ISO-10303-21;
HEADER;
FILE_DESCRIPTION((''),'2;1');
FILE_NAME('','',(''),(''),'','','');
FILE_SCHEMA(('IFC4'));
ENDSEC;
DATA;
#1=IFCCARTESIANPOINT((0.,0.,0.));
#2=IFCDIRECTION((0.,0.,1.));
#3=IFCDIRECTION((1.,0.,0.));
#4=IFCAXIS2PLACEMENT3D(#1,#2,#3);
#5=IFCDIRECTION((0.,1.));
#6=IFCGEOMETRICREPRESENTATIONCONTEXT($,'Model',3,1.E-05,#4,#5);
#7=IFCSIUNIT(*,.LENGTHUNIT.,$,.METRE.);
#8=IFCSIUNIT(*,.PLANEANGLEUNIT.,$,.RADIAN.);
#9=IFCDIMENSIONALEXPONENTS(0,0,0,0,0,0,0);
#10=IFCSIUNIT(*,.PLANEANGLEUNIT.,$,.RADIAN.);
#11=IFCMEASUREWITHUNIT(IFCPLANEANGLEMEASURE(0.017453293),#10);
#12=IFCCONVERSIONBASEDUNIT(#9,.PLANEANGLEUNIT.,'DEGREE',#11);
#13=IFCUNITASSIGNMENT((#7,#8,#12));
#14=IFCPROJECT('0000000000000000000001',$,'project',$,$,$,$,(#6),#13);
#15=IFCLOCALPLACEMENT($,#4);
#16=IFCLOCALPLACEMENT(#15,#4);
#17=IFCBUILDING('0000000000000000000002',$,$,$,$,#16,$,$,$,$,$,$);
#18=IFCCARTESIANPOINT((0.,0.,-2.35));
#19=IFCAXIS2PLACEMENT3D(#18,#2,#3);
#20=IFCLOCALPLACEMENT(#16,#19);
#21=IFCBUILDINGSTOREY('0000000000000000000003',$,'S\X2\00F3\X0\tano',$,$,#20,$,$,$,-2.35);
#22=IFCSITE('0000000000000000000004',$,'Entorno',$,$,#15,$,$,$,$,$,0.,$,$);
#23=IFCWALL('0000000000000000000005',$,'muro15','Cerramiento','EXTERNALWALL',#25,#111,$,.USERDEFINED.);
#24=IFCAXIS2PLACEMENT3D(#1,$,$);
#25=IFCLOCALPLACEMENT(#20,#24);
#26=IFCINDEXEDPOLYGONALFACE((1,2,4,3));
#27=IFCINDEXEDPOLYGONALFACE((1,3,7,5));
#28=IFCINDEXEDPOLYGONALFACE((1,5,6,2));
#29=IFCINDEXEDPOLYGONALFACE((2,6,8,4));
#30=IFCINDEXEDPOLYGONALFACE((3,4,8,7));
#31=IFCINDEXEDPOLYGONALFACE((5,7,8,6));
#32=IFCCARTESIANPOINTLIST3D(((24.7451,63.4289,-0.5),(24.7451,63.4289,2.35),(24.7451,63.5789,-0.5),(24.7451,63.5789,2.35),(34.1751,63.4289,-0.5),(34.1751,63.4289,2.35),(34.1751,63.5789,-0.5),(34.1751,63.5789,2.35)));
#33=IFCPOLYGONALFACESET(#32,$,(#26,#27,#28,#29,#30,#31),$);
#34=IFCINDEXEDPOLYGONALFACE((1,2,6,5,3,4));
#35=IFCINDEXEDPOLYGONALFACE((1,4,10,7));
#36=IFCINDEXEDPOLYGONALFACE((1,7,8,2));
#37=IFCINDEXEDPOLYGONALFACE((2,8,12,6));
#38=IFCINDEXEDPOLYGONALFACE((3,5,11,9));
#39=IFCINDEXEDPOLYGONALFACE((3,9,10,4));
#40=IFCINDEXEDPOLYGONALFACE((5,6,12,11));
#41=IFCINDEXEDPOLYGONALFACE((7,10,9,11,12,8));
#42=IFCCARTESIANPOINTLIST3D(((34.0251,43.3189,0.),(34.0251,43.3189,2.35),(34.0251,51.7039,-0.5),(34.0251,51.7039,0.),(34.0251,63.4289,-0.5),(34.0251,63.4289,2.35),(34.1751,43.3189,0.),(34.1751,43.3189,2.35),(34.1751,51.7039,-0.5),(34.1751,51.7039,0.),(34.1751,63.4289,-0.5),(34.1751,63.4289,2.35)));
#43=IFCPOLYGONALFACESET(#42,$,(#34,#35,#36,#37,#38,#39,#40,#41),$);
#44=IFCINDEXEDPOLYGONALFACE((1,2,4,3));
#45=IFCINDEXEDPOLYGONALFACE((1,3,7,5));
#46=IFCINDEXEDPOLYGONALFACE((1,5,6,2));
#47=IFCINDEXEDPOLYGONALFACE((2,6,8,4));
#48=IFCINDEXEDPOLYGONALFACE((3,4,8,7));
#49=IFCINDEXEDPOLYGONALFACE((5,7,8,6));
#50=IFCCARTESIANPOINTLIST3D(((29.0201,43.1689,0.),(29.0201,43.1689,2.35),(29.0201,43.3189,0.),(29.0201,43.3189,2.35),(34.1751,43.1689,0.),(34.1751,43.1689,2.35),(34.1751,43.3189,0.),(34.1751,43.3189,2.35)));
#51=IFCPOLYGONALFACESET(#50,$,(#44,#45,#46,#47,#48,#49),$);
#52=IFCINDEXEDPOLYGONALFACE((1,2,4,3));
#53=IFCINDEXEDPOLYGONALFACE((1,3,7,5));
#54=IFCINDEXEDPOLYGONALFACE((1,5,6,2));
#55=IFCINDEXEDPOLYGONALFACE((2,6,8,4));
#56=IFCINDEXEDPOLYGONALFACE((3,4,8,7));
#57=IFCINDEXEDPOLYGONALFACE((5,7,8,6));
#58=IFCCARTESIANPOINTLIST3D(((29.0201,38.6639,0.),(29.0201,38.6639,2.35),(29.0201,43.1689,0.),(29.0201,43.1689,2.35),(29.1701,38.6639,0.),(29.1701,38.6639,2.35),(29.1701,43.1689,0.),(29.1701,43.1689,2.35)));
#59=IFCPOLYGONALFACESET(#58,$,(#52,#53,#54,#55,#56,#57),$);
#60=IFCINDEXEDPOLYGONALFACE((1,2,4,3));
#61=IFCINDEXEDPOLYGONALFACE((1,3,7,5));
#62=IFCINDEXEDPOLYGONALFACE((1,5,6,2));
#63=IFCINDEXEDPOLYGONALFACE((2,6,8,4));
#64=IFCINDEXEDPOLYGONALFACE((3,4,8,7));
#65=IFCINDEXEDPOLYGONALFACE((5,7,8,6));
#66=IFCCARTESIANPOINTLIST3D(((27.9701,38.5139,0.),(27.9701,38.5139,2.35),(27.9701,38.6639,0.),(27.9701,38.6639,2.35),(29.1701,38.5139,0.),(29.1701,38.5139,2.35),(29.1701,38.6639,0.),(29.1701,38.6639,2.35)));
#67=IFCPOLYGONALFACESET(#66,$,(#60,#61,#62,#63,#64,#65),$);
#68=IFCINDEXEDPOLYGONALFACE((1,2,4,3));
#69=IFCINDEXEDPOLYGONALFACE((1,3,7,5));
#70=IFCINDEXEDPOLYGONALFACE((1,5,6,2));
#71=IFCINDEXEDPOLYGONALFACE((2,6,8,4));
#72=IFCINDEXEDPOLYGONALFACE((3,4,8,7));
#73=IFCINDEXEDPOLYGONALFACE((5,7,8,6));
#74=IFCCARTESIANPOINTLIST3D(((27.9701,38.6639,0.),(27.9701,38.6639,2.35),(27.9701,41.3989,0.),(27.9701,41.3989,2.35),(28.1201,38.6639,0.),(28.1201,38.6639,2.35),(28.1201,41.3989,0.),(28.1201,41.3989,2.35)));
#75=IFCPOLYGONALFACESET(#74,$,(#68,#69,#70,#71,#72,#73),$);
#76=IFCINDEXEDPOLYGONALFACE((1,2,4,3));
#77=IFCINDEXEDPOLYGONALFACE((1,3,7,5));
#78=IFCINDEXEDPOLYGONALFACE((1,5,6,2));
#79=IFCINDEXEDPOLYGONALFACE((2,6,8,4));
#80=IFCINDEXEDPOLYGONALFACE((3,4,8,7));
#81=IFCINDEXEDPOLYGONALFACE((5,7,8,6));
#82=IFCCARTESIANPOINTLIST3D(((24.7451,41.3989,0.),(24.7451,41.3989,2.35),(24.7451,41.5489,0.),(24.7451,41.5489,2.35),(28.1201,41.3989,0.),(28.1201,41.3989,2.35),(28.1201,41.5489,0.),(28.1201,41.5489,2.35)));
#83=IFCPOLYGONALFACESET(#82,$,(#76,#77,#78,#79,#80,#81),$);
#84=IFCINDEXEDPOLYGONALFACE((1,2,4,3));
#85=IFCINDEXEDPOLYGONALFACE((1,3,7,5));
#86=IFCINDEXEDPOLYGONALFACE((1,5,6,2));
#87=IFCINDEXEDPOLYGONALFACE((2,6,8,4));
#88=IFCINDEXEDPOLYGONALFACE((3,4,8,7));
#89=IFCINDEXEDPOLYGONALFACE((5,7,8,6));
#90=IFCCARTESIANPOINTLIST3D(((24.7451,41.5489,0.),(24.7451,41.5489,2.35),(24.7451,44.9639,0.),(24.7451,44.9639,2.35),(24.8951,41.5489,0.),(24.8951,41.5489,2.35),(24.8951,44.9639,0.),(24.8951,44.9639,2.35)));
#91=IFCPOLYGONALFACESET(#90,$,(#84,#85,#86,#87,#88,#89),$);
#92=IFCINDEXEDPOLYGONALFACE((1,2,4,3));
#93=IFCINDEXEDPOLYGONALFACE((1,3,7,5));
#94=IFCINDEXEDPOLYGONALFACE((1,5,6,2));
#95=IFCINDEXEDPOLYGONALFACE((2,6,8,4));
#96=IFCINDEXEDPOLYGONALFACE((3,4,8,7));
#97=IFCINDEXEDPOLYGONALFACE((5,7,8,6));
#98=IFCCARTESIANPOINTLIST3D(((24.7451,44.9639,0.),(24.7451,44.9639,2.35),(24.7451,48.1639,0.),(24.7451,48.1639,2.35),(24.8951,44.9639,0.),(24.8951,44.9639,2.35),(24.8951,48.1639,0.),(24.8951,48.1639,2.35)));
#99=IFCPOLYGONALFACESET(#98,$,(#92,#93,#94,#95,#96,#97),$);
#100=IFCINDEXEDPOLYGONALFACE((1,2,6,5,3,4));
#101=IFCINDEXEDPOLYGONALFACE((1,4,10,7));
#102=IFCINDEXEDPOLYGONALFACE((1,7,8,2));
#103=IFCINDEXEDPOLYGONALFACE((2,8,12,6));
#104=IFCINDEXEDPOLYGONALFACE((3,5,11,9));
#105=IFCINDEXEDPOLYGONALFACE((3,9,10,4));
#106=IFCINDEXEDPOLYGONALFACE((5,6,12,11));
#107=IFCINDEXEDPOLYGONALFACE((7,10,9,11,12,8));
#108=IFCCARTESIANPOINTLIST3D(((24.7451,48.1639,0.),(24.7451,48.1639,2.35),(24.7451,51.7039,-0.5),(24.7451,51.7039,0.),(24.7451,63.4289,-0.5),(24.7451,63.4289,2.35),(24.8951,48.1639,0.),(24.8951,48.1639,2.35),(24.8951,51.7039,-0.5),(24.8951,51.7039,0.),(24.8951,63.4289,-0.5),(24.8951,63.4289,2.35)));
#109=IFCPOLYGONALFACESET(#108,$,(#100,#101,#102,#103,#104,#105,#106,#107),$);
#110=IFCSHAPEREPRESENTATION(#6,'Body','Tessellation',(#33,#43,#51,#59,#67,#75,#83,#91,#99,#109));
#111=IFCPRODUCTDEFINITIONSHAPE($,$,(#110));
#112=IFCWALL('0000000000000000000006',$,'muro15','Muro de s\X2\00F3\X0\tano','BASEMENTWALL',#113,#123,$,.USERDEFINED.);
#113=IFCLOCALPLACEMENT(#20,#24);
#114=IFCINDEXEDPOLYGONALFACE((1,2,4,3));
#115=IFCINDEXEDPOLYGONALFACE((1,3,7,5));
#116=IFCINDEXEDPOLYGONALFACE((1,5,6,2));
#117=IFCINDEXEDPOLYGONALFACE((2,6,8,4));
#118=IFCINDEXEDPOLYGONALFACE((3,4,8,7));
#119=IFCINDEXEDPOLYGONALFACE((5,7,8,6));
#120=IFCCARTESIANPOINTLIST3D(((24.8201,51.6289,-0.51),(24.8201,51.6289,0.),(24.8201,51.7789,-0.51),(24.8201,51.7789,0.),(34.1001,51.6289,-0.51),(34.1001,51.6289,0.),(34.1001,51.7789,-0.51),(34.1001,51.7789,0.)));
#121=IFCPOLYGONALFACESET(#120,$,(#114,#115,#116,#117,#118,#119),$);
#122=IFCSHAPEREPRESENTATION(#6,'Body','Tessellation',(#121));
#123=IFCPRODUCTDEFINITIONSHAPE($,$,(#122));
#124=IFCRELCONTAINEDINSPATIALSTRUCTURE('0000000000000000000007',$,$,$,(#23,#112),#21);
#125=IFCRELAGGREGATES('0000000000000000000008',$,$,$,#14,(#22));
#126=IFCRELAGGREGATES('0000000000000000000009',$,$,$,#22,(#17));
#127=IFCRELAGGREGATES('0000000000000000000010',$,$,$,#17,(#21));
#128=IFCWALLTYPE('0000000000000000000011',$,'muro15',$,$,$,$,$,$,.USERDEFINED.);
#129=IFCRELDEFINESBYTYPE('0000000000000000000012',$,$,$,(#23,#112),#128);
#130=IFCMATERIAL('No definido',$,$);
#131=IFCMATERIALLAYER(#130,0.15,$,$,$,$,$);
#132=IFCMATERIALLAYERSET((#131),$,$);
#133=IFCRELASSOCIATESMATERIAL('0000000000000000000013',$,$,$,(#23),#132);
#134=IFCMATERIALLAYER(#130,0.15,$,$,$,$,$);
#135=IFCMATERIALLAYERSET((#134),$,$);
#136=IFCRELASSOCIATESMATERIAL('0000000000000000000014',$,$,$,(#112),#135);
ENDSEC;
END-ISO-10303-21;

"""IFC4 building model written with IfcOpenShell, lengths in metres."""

from ifc_helpers import new_model, entity, si_unit, converted_unit, direction, frame, origin_with_axes, place, context, project, spatial, material, layer, layer_set, layer_usage, type_object, element, save


model = new_model("IFC4")

# Units and contexts
model_context = context("Model", 3, precision=1e-05, world=origin_with_axes(), true_north=direction((0.0, 1.0)))
ifc_project = project(units=[si_unit("LENGTHUNIT", "METRE"), si_unit("PLANEANGLEUNIT", "RADIAN"), converted_unit("PLANEANGLEUNIT", "DEGREE", entity("IfcPlaneAngleMeasure", 0.017453293), si_unit("PLANEANGLEUNIT", "RADIAN"), dimensions=[0, 0, 0, 0, 0, 0, 0])], contexts=[model_context])

# Site, building, storey
site_placement = place(None, origin_with_axes())
site = spatial("IfcSite", under=ifc_project, at=site_placement, Name="Entorno", RefElevation=0.0)
building_placement = place(site_placement, origin_with_axes())
building = spatial("IfcBuilding", under=site, at=building_placement)
storey_placement = place(building_placement, frame((0.0, 0.0, -2.35), z_axis=(0.0, 0.0, 1.0), x_axis=(1.0, 0.0, 0.0)))
storey = spatial("IfcBuildingStorey", under=building, at=storey_placement, Name="Sótano", Elevation=-2.35)

# Shared definitions
ifc_material = material(Name="No definido")

# Walls
ifc_layer_1 = layer(ifc_material, 0.15)
ifc_layer_set_1 = layer_set([ifc_layer_1])
ifc_layer_usage_1 = layer_usage(ifc_layer_set_1, "AXIS2", "POSITIVE", -0.075)
wall_type_1 = type_object("IfcWallType", Name="muro15", PredefinedType="USERDEFINED")
wall_1_placement = place(storey_placement, frame((24.8201, 63.5039, 0.0), z_axis=(0.0, 0.0, 1.0), x_axis=(1.0, 0.0, 0.0)))
cartesian_point_1 = entity("IfcCartesianPoint", [-4.715, -1.425])
cartesian_point_2 = entity("IfcCartesianPoint", [-4.715, -1.425])
cartesian_point_3 = entity("IfcCartesianPoint", [-10.055, -1.425])
cartesian_point_4 = entity("IfcCartesianPoint", [-10.055, -1.425])
cartesian_point_5 = entity("IfcCartesianPoint", [-2.5775, -1.175])
cartesian_point_6 = entity("IfcCartesianPoint", [-2.5775, -1.175])
cartesian_point_7 = entity("IfcCartesianPoint", [-2.2525, -1.175])
cartesian_point_8 = entity("IfcCartesianPoint", [-2.2525, -1.175])
cartesian_point_9 = entity("IfcCartesianPoint", [-0.6, -1.175])
cartesian_point_10 = entity("IfcCartesianPoint", [-0.6, -1.175])
cartesian_point_11 = entity("IfcCartesianPoint", [-1.3675, -1.175])
cartesian_point_12 = entity("IfcCartesianPoint", [-1.3675, -1.175])
cartesian_point_13 = entity("IfcCartesianPoint", [-1.6875, -1.175])
cartesian_point_14 = entity("IfcCartesianPoint", [-1.6875, -1.175])
cartesian_point_15 = entity("IfcCartesianPoint", [-1.7075, -1.175])
cartesian_point_16 = entity("IfcCartesianPoint", [-1.7075, -1.175])
cartesian_point_17 = entity("IfcCartesianPoint", [-1.6, -1.175])
cartesian_point_18 = entity("IfcCartesianPoint", [-1.6, -1.175])
cartesian_point_19 = entity("IfcCartesianPoint", [-7.6325, -0.925])
cartesian_point_20 = entity("IfcCartesianPoint", [-7.6325, -0.925])
element("IfcWall", 1, at=wall_1_placement, inside=storey, type_object=wall_type_1, material=ifc_layer_usage_1, Name="muro15", Description="Cerramiento", ObjectType="EXTERNALWALL", PredefinedType="USERDEFINED", context=model_context, shape_type="SolidModel", body=[
    entity("IfcExtrudedAreaSolidTapered", entity("IfcArbitraryClosedProfileDef", "AREA", None, entity("IfcPolyline", [cartesian_point_1, entity("IfcCartesianPoint", [4.715, -1.425]), entity("IfcCartesianPoint", [4.715, 1.425]), entity("IfcCartesianPoint", [-4.715, 1.425]), cartesian_point_1])), entity("IfcAxis2Placement3D", entity("IfcCartesianPoint", [4.64, 0.075, 0.925]), entity("IfcDirection", [0.0, -1.0, 0.0]), entity("IfcDirection", [1.0, 0.0, 0.0])), entity("IfcDirection", [0.0, 0.0, 1.0]), 0.15, entity("IfcArbitraryClosedProfileDef", "AREA", None, entity("IfcPolyline", [cartesian_point_2, entity("IfcCartesianPoint", [4.715, -1.425]), entity("IfcCartesianPoint", [4.715, 1.425]), entity("IfcCartesianPoint", [-4.715, 1.425]), cartesian_point_2]))),
    entity("IfcExtrudedAreaSolidTapered", entity("IfcArbitraryClosedProfileDef", "AREA", None, entity("IfcPolyline", [cartesian_point_3, entity("IfcCartesianPoint", [1.67, -1.425]), entity("IfcCartesianPoint", [1.67, -0.925]), entity("IfcCartesianPoint", [10.055, -0.925]), entity("IfcCartesianPoint", [10.055, 1.425]), entity("IfcCartesianPoint", [-10.055, 1.425]), cartesian_point_3])), entity("IfcAxis2Placement3D", entity("IfcCartesianPoint", [9.355, -10.13, 0.925]), entity("IfcDirection", [-1.0, 0.0, 0.0]), entity("IfcDirection", [0.0, -1.0, 0.0])), entity("IfcDirection", [0.0, 0.0, 1.0]), 0.15, entity("IfcArbitraryClosedProfileDef", "AREA", None, entity("IfcPolyline", [cartesian_point_4, entity("IfcCartesianPoint", [1.67, -1.425]), entity("IfcCartesianPoint", [1.67, -0.925]), entity("IfcCartesianPoint", [10.055, -0.925]), entity("IfcCartesianPoint", [10.055, 1.425]), entity("IfcCartesianPoint", [-10.055, 1.425]), cartesian_point_4]))),
    entity("IfcExtrudedAreaSolidTapered", entity("IfcArbitraryClosedProfileDef", "AREA", None, entity("IfcPolyline", [cartesian_point_5, entity("IfcCartesianPoint", [2.5775, -1.175]), entity("IfcCartesianPoint", [2.5775, 1.175]), entity("IfcCartesianPoint", [-2.5775, 1.175]), cartesian_point_5])), entity("IfcAxis2Placement3D", entity("IfcCartesianPoint", [6.7775, -20.335, 1.175]), entity("IfcDirection", [0.0, 1.0, 0.0]), entity("IfcDirection", [-1.0, 0.0, 0.0])), entity("IfcDirection", [0.0, 0.0, 1.0]), 0.15, entity("IfcArbitraryClosedProfileDef", "AREA", None, entity("IfcPolyline", [cartesian_point_6, entity("IfcCartesianPoint", [2.5775, -1.175]), entity("IfcCartesianPoint", [2.5775, 1.175]), entity("IfcCartesianPoint", [-2.5775, 1.175]), cartesian_point_6]))),
    entity("IfcExtrudedAreaSolidTapered", entity("IfcArbitraryClosedProfileDef", "AREA", None, entity("IfcPolyline", [cartesian_point_7, entity("IfcCartesianPoint", [2.2525, -1.175]), entity("IfcCartesianPoint", [2.2525, 1.175]), entity("IfcCartesianPoint", [-2.2525, 1.175]), cartesian_point_7])), entity("IfcAxis2Placement3D", entity("IfcCartesianPoint", [4.35, -22.5875, 1.175]), entity("IfcDirection", [-1.0, 0.0, 0.0]), entity("IfcDirection", [0.0, -1.0, 0.0])), entity("IfcDirection", [0.0, 0.0, 1.0]), 0.15, entity("IfcArbitraryClosedProfileDef", "AREA", None, entity("IfcPolyline", [cartesian_point_8, entity("IfcCartesianPoint", [2.2525, -1.175]), entity("IfcCartesianPoint", [2.2525, 1.175]), entity("IfcCartesianPoint", [-2.2525, 1.175]), cartesian_point_8]))),
    entity("IfcExtrudedAreaSolidTapered", entity("IfcArbitraryClosedProfileDef", "AREA", None, entity("IfcPolyline", [cartesian_point_9, entity("IfcCartesianPoint", [0.6, -1.175]), entity("IfcCartesianPoint", [0.6, 1.175]), entity("IfcCartesianPoint", [-0.6, 1.175]), cartesian_point_9])), entity("IfcAxis2Placement3D", entity("IfcCartesianPoint", [3.75, -24.99, 1.175]), entity("IfcDirection", [0.0, 1.0, 0.0]), entity("IfcDirection", [-1.0, 0.0, 0.0])), entity("IfcDirection", [0.0, 0.0, 1.0]), 0.15, entity("IfcArbitraryClosedProfileDef", "AREA", None, entity("IfcPolyline", [cartesian_point_10, entity("IfcCartesianPoint", [0.6, -1.175]), entity("IfcCartesianPoint", [0.6, 1.175]), entity("IfcCartesianPoint", [-0.6, 1.175]), cartesian_point_10]))),
    entity("IfcExtrudedAreaSolidTapered", entity("IfcArbitraryClosedProfileDef", "AREA", None, entity("IfcPolyline", [cartesian_point_11, entity("IfcCartesianPoint", [1.3675, -1.175]), entity("IfcCartesianPoint", [1.3675, 1.175]), entity("IfcCartesianPoint", [-1.3675, 1.175]), cartesian_point_11])), entity("IfcAxis2Placement3D", entity("IfcCartesianPoint", [3.15, -23.4725, 1.175]), entity("IfcDirection", [1.0, 0.0, 0.0]), entity("IfcDirection", [0.0, 1.0, 0.0])), entity("IfcDirection", [0.0, 0.0, 1.0]), 0.15, entity("IfcArbitraryClosedProfileDef", "AREA", None, entity("IfcPolyline", [cartesian_point_12, entity("IfcCartesianPoint", [1.3675, -1.175]), entity("IfcCartesianPoint", [1.3675, 1.175]), entity("IfcCartesianPoint", [-1.3675, 1.175]), cartesian_point_12]))),
    entity("IfcExtrudedAreaSolidTapered", entity("IfcArbitraryClosedProfileDef", "AREA", None, entity("IfcPolyline", [cartesian_point_13, entity("IfcCartesianPoint", [1.6875, -1.175]), entity("IfcCartesianPoint", [1.6875, 1.175]), entity("IfcCartesianPoint", [-1.6875, 1.175]), cartesian_point_13])), entity("IfcAxis2Placement3D", entity("IfcCartesianPoint", [1.6125, -22.105, 1.175]), entity("IfcDirection", [0.0, 1.0, 0.0]), entity("IfcDirection", [-1.0, 0.0, 0.0])), entity("IfcDirection", [0.0, 0.0, 1.0]), 0.15, entity("IfcArbitraryClosedProfileDef", "AREA", None, entity("IfcPolyline", [cartesian_point_14, entity("IfcCartesianPoint", [1.6875, -1.175]), entity("IfcCartesianPoint", [1.6875, 1.175]), entity("IfcCartesianPoint", [-1.6875, 1.175]), cartesian_point_14]))),
    entity("IfcExtrudedAreaSolidTapered", entity("IfcArbitraryClosedProfileDef", "AREA", None, entity("IfcPolyline", [cartesian_point_15, entity("IfcCartesianPoint", [1.7075, -1.175]), entity("IfcCartesianPoint", [1.7075, 1.175]), entity("IfcCartesianPoint", [-1.7075, 1.175]), cartesian_point_15])), entity("IfcAxis2Placement3D", entity("IfcCartesianPoint", [-0.075, -20.2475, 1.175]), entity("IfcDirection", [1.0, 0.0, 0.0]), entity("IfcDirection", [0.0, 1.0, 0.0])), entity("IfcDirection", [0.0, 0.0, 1.0]), 0.15, entity("IfcArbitraryClosedProfileDef", "AREA", None, entity("IfcPolyline", [cartesian_point_16, entity("IfcCartesianPoint", [1.7075, -1.175]), entity("IfcCartesianPoint", [1.7075, 1.175]), entity("IfcCartesianPoint", [-1.7075, 1.175]), cartesian_point_16]))),
    entity("IfcExtrudedAreaSolidTapered", entity("IfcArbitraryClosedProfileDef", "AREA", None, entity("IfcPolyline", [cartesian_point_17, entity("IfcCartesianPoint", [1.6, -1.175]), entity("IfcCartesianPoint", [1.6, 1.175]), entity("IfcCartesianPoint", [-1.6, 1.175]), cartesian_point_17])), entity("IfcAxis2Placement3D", entity("IfcCartesianPoint", [-0.075, -16.94, 1.175]), entity("IfcDirection", [1.0, 0.0, 0.0]), entity("IfcDirection", [0.0, 1.0, 0.0])), entity("IfcDirection", [0.0, 0.0, 1.0]), 0.15, entity("IfcArbitraryClosedProfileDef", "AREA", None, entity("IfcPolyline", [cartesian_point_18, entity("IfcCartesianPoint", [1.6, -1.175]), entity("IfcCartesianPoint", [1.6, 1.175]), entity("IfcCartesianPoint", [-1.6, 1.175]), cartesian_point_18]))),
    entity("IfcExtrudedAreaSolidTapered", entity("IfcArbitraryClosedProfileDef", "AREA", None, entity("IfcPolyline", [cartesian_point_19, entity("IfcCartesianPoint", [-4.0925, -0.925]), entity("IfcCartesianPoint", [-4.0925, -1.425]), entity("IfcCartesianPoint", [7.6325, -1.425]), entity("IfcCartesianPoint", [7.6325, 1.425]), entity("IfcCartesianPoint", [-7.6325, 1.425]), cartesian_point_19])), entity("IfcAxis2Placement3D", entity("IfcCartesianPoint", [-0.075, -7.7075, 0.925]), entity("IfcDirection", [1.0, 0.0, 0.0]), entity("IfcDirection", [0.0, 1.0, 0.0])), entity("IfcDirection", [0.0, 0.0, 1.0]), 0.15, entity("IfcArbitraryClosedProfileDef", "AREA", None, entity("IfcPolyline", [cartesian_point_20, entity("IfcCartesianPoint", [-4.0925, -0.925]), entity("IfcCartesianPoint", [-4.0925, -1.425]), entity("IfcCartesianPoint", [7.6325, -1.425]), entity("IfcCartesianPoint", [7.6325, 1.425]), entity("IfcCartesianPoint", [-7.6325, 1.425]), cartesian_point_20]))),
])
ifc_layer_2 = layer(ifc_material, 0.15)
ifc_layer_set_2 = layer_set([ifc_layer_2])
ifc_layer_usage_2 = layer_usage(ifc_layer_set_2, "AXIS2", "POSITIVE", -0.075)
wall_2_placement = place(storey_placement, frame((24.8201, 51.7039, 0.0), z_axis=(0.0, 0.0, 1.0), x_axis=(1.0, 0.0, 0.0)))
cartesian_point_21 = entity("IfcCartesianPoint", [-4.64, -0.255])
cartesian_point_22 = entity("IfcCartesianPoint", [-4.64, -0.255])
element("IfcWall", 2, at=wall_2_placement, inside=storey, type_object=wall_type_1, material=ifc_layer_usage_2, Name="muro15", Description="Muro de sótano", ObjectType="BASEMENTWALL", PredefinedType="USERDEFINED", context=model_context, shape_type="SolidModel", body=[
    entity("IfcExtrudedAreaSolidTapered", entity("IfcArbitraryClosedProfileDef", "AREA", None, entity("IfcPolyline", [cartesian_point_21, entity("IfcCartesianPoint", [4.64, -0.255]), entity("IfcCartesianPoint", [4.64, 0.255]), entity("IfcCartesianPoint", [-4.64, 0.255]), cartesian_point_21])), entity("IfcAxis2Placement3D", entity("IfcCartesianPoint", [4.64, 0.075, -0.255]), entity("IfcDirection", [0.0, -1.0, 0.0]), entity("IfcDirection", [1.0, 0.0, 0.0])), entity("IfcDirection", [0.0, 0.0, 1.0]), 0.15, entity("IfcArbitraryClosedProfileDef", "AREA", None, entity("IfcPolyline", [cartesian_point_22, entity("IfcCartesianPoint", [4.64, -0.255]), entity("IfcCartesianPoint", [4.64, 0.255]), entity("IfcCartesianPoint", [-4.64, 0.255]), cartesian_point_22]))),
])

save(model, "model.ifc")
